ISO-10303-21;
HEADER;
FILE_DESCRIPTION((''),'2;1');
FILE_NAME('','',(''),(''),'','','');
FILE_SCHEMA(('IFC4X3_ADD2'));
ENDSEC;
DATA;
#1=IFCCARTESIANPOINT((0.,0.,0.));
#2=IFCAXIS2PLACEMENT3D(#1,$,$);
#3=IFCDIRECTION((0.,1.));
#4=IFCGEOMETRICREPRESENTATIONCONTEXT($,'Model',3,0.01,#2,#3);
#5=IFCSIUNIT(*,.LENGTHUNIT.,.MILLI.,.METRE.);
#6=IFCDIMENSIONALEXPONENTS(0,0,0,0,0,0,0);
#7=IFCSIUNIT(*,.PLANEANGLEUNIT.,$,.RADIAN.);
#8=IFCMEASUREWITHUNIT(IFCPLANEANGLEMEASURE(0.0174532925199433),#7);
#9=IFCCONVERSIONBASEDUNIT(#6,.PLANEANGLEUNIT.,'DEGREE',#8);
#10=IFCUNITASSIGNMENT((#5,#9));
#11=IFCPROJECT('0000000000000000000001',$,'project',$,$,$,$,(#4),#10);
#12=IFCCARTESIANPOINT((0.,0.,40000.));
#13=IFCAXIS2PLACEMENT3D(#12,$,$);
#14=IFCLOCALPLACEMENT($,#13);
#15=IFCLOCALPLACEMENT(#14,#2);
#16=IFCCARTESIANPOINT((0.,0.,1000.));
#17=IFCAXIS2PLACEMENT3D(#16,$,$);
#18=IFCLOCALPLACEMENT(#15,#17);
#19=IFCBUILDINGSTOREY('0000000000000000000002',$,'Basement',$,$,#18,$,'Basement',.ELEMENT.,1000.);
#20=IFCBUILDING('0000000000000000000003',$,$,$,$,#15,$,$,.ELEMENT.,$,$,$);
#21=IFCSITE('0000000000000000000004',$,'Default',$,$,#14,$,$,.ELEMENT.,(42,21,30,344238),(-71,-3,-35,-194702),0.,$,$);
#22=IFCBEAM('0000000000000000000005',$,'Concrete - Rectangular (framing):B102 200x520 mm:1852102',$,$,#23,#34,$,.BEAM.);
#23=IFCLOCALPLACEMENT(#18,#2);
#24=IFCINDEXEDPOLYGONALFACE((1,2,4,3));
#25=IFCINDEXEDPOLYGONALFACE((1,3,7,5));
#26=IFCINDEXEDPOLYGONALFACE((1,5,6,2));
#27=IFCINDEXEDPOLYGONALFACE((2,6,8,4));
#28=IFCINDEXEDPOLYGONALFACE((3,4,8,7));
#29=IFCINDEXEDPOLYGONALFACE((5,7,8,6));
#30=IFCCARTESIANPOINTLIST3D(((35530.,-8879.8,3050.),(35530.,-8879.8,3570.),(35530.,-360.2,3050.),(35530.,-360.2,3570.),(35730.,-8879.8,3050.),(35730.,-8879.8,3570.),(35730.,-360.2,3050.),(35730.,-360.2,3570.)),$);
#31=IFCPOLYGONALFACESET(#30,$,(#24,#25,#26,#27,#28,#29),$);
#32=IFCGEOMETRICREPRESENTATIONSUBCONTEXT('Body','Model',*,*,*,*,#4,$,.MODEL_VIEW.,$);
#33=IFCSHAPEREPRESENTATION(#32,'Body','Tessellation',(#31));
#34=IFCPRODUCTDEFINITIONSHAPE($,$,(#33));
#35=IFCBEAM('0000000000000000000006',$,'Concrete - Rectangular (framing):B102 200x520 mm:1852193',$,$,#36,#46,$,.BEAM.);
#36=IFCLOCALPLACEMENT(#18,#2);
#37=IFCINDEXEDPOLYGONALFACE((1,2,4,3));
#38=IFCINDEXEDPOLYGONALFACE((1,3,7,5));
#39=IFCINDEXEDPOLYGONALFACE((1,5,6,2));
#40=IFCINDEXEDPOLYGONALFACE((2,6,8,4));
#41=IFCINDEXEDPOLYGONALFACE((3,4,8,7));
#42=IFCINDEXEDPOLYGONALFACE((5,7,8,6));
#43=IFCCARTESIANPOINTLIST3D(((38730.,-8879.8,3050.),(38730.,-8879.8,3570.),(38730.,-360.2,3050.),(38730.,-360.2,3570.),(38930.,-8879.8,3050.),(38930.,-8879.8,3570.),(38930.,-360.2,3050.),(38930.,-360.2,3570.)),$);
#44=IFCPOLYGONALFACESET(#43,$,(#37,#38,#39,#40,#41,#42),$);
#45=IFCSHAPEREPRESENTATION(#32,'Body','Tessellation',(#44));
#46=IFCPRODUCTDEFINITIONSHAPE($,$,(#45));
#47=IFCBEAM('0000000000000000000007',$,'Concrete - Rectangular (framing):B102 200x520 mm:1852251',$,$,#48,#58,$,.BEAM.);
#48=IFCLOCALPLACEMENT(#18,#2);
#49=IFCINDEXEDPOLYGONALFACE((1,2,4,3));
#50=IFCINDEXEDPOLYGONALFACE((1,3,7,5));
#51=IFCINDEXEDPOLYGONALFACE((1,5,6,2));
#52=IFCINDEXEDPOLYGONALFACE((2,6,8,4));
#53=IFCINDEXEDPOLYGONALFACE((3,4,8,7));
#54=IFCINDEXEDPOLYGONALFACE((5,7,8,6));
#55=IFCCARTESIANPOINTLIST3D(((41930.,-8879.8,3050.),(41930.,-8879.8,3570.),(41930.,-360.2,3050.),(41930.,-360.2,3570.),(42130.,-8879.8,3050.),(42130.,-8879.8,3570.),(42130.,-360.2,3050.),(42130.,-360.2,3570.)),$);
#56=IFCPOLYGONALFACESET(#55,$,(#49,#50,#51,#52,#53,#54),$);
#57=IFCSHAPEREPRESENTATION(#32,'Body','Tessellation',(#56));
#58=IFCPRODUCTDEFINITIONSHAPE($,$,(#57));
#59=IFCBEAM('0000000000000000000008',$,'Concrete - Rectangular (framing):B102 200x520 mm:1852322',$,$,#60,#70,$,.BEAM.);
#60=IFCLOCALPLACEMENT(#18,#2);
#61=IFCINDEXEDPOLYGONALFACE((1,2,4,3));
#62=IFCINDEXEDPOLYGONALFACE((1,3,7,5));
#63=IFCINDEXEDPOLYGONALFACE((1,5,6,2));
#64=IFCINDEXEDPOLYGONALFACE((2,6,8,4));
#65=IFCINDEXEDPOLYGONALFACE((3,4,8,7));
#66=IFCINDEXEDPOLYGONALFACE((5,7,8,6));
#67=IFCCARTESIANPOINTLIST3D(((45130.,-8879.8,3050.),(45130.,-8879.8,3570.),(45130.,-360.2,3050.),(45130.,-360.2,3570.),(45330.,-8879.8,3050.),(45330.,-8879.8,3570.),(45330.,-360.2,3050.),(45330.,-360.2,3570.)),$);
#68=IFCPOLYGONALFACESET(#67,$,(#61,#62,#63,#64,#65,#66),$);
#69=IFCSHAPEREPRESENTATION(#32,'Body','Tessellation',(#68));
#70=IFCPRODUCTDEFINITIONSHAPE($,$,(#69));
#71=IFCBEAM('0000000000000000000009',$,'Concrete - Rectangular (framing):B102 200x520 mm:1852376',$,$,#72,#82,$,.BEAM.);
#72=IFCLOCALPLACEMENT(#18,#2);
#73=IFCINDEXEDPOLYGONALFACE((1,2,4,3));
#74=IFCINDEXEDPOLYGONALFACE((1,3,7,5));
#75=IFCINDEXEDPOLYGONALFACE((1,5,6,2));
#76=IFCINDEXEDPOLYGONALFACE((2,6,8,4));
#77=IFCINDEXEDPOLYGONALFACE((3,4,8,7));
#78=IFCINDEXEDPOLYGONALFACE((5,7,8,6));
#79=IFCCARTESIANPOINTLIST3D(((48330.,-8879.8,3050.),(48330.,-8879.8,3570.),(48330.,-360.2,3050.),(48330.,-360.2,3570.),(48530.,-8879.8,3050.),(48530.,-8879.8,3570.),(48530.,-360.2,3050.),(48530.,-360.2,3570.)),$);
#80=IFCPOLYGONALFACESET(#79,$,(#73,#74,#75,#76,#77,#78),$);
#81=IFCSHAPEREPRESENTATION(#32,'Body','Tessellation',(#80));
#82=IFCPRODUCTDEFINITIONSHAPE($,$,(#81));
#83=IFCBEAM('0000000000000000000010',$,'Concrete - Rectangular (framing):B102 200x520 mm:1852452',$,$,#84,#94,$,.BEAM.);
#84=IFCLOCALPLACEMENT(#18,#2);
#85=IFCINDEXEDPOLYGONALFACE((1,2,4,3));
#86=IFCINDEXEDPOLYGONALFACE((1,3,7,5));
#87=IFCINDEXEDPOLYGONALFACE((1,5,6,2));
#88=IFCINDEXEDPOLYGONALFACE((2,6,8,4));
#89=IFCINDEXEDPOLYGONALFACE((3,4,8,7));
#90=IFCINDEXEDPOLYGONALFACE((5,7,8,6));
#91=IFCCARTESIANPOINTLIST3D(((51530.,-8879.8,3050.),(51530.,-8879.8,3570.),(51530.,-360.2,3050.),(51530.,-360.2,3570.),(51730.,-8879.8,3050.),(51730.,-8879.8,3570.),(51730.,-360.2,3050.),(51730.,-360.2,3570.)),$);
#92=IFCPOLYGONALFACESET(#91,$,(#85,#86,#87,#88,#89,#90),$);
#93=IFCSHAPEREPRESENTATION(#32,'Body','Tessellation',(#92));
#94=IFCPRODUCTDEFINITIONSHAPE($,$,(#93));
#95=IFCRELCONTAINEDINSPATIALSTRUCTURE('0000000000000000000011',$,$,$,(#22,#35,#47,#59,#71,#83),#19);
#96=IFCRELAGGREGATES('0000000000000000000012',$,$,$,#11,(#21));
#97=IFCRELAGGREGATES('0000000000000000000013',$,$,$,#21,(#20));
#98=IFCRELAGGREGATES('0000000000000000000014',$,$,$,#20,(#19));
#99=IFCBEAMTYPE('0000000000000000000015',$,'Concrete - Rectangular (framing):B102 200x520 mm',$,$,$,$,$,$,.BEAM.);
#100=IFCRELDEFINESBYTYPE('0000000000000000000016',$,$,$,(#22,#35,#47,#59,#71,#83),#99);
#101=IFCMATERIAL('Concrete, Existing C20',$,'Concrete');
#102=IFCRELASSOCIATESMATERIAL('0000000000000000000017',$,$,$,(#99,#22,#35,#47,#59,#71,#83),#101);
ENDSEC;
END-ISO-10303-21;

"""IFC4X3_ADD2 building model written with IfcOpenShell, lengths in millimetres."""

from ifc_helpers import new_model, entity, si_unit, converted_unit, direction, frame, origin, origin_2d_with_axis, place, context, subcontext, project, spatial, rectangle, extrude, source, transform, mapped, material, material_profile, profile_set, profile_usage, type_object, type_shapes, element, save


model = new_model("IFC4X3_ADD2")

# Units and contexts
model_context = context("Model", 3, precision=0.01, world=origin(), true_north=direction((0.0, 1.0)))
body_context = subcontext(model_context, "Body", "Model", "MODEL_VIEW")
ifc_project = project(units=[si_unit("LENGTHUNIT", "METRE", prefix="MILLI"), converted_unit("PLANEANGLEUNIT", "DEGREE", entity("IfcPlaneAngleMeasure", 0.0174532925199433), si_unit("PLANEANGLEUNIT", "RADIAN"), dimensions=[0, 0, 0, 0, 0, 0, 0])], contexts=[model_context])

# Site, building, storey
site_placement = place(None, frame((0.0, 0.0, 40000.0)))
site = spatial("IfcSite", under=ifc_project, at=site_placement, Name="Default", CompositionType="ELEMENT", RefLatitude=(42, 21, 30, 344238), RefLongitude=(-71, -3, -35, -194702), RefElevation=0.0)
building_placement = place(site_placement, origin())
building = spatial("IfcBuilding", under=site, at=building_placement, CompositionType="ELEMENT")
storey_placement = place(building_placement, frame((0.0, 0.0, 1000.0)))
storey = spatial("IfcBuildingStorey", under=building, at=storey_placement, Name="Basement", LongName="Basement", CompositionType="ELEMENT", Elevation=1000.0)

# Shared definitions
ifc_material_1 = material(Name="Concrete, Existing C20", Category="Concrete")

# Beams
ifc_material_profile_1 = material_profile(ifc_material_1, rectangle(XDim=8519.8, YDim=200.0, at=origin_2d_with_axis()), Name="B102 200x520 mm")
ifc_profile_set_1 = profile_set([ifc_material_profile_1], Name="B102 200x520 mm")
ifc_profile_usage_1 = profile_usage(ifc_profile_set_1, cardinal=8)
beam_type_1 = type_object("IfcBeamType", Name="Concrete - Rectangular (framing):B102 200x520 mm", PredefinedType="BEAM", material=ifc_profile_set_1)
shared_shape_1 = source(origin(), body_context, "Body", "SweptSolid", [
    extrude(rectangle(XDim=8519.6, YDim=200.0, at=origin_2d_with_axis()), frame((0.0, 0.0, -260.0), z_axis=(0.0, 0.0, 1.0), x_axis=(-1.0, 0.0, 0.0)), (0.0, 0.0, 1.0), 520.0),
])
type_shapes(beam_type_1, [shared_shape_1])
for number, where, z_axis, x_axis, name in (
    (1, (35630.0, -4620.0, 3310.0), (0.0, 0.0, 1.0), (0.0, -1.0, 0.0), "Concrete - Rectangular (framing):B102 200x520 mm:1852102"),
    (2, (38830.0, -4620.0, 3310.0), (0.0, 0.0, 1.0), (0.0, -1.0, 0.0), "Concrete - Rectangular (framing):B102 200x520 mm:1852193"),
    (3, (42030.0, -4620.0, 3310.0), (0.0, 0.0, 1.0), (0.0, -1.0, 0.0), "Concrete - Rectangular (framing):B102 200x520 mm:1852251"),
    (4, (45230.0, -4620.0, 3310.0), (0.0, 0.0, 1.0), (0.0, -1.0, 0.0), "Concrete - Rectangular (framing):B102 200x520 mm:1852322"),
    (5, (48430.0, -4620.0, 3310.0), (0.0, 0.0, 1.0), (0.0, -1.0, 0.0), "Concrete - Rectangular (framing):B102 200x520 mm:1852376"),
    (6, (51630.0, -4620.0, 3310.0), (0.0, 0.0, 1.0), (0.0, -1.0, 0.0), "Concrete - Rectangular (framing):B102 200x520 mm:1852452"),
):
    element("IfcBeam", number, at=place(storey_placement, frame(where, z_axis=z_axis, x_axis=x_axis)), inside=storey, type_object=beam_type_1, material=ifc_profile_usage_1, Name=name, PredefinedType="BEAM", context=body_context, shape_type="MappedRepresentation", body=[
        mapped(shared_shape_1, transform((0.0, 0.0, 0.0), scale=1.0)),
    ])

save(model, "model.ifc")
